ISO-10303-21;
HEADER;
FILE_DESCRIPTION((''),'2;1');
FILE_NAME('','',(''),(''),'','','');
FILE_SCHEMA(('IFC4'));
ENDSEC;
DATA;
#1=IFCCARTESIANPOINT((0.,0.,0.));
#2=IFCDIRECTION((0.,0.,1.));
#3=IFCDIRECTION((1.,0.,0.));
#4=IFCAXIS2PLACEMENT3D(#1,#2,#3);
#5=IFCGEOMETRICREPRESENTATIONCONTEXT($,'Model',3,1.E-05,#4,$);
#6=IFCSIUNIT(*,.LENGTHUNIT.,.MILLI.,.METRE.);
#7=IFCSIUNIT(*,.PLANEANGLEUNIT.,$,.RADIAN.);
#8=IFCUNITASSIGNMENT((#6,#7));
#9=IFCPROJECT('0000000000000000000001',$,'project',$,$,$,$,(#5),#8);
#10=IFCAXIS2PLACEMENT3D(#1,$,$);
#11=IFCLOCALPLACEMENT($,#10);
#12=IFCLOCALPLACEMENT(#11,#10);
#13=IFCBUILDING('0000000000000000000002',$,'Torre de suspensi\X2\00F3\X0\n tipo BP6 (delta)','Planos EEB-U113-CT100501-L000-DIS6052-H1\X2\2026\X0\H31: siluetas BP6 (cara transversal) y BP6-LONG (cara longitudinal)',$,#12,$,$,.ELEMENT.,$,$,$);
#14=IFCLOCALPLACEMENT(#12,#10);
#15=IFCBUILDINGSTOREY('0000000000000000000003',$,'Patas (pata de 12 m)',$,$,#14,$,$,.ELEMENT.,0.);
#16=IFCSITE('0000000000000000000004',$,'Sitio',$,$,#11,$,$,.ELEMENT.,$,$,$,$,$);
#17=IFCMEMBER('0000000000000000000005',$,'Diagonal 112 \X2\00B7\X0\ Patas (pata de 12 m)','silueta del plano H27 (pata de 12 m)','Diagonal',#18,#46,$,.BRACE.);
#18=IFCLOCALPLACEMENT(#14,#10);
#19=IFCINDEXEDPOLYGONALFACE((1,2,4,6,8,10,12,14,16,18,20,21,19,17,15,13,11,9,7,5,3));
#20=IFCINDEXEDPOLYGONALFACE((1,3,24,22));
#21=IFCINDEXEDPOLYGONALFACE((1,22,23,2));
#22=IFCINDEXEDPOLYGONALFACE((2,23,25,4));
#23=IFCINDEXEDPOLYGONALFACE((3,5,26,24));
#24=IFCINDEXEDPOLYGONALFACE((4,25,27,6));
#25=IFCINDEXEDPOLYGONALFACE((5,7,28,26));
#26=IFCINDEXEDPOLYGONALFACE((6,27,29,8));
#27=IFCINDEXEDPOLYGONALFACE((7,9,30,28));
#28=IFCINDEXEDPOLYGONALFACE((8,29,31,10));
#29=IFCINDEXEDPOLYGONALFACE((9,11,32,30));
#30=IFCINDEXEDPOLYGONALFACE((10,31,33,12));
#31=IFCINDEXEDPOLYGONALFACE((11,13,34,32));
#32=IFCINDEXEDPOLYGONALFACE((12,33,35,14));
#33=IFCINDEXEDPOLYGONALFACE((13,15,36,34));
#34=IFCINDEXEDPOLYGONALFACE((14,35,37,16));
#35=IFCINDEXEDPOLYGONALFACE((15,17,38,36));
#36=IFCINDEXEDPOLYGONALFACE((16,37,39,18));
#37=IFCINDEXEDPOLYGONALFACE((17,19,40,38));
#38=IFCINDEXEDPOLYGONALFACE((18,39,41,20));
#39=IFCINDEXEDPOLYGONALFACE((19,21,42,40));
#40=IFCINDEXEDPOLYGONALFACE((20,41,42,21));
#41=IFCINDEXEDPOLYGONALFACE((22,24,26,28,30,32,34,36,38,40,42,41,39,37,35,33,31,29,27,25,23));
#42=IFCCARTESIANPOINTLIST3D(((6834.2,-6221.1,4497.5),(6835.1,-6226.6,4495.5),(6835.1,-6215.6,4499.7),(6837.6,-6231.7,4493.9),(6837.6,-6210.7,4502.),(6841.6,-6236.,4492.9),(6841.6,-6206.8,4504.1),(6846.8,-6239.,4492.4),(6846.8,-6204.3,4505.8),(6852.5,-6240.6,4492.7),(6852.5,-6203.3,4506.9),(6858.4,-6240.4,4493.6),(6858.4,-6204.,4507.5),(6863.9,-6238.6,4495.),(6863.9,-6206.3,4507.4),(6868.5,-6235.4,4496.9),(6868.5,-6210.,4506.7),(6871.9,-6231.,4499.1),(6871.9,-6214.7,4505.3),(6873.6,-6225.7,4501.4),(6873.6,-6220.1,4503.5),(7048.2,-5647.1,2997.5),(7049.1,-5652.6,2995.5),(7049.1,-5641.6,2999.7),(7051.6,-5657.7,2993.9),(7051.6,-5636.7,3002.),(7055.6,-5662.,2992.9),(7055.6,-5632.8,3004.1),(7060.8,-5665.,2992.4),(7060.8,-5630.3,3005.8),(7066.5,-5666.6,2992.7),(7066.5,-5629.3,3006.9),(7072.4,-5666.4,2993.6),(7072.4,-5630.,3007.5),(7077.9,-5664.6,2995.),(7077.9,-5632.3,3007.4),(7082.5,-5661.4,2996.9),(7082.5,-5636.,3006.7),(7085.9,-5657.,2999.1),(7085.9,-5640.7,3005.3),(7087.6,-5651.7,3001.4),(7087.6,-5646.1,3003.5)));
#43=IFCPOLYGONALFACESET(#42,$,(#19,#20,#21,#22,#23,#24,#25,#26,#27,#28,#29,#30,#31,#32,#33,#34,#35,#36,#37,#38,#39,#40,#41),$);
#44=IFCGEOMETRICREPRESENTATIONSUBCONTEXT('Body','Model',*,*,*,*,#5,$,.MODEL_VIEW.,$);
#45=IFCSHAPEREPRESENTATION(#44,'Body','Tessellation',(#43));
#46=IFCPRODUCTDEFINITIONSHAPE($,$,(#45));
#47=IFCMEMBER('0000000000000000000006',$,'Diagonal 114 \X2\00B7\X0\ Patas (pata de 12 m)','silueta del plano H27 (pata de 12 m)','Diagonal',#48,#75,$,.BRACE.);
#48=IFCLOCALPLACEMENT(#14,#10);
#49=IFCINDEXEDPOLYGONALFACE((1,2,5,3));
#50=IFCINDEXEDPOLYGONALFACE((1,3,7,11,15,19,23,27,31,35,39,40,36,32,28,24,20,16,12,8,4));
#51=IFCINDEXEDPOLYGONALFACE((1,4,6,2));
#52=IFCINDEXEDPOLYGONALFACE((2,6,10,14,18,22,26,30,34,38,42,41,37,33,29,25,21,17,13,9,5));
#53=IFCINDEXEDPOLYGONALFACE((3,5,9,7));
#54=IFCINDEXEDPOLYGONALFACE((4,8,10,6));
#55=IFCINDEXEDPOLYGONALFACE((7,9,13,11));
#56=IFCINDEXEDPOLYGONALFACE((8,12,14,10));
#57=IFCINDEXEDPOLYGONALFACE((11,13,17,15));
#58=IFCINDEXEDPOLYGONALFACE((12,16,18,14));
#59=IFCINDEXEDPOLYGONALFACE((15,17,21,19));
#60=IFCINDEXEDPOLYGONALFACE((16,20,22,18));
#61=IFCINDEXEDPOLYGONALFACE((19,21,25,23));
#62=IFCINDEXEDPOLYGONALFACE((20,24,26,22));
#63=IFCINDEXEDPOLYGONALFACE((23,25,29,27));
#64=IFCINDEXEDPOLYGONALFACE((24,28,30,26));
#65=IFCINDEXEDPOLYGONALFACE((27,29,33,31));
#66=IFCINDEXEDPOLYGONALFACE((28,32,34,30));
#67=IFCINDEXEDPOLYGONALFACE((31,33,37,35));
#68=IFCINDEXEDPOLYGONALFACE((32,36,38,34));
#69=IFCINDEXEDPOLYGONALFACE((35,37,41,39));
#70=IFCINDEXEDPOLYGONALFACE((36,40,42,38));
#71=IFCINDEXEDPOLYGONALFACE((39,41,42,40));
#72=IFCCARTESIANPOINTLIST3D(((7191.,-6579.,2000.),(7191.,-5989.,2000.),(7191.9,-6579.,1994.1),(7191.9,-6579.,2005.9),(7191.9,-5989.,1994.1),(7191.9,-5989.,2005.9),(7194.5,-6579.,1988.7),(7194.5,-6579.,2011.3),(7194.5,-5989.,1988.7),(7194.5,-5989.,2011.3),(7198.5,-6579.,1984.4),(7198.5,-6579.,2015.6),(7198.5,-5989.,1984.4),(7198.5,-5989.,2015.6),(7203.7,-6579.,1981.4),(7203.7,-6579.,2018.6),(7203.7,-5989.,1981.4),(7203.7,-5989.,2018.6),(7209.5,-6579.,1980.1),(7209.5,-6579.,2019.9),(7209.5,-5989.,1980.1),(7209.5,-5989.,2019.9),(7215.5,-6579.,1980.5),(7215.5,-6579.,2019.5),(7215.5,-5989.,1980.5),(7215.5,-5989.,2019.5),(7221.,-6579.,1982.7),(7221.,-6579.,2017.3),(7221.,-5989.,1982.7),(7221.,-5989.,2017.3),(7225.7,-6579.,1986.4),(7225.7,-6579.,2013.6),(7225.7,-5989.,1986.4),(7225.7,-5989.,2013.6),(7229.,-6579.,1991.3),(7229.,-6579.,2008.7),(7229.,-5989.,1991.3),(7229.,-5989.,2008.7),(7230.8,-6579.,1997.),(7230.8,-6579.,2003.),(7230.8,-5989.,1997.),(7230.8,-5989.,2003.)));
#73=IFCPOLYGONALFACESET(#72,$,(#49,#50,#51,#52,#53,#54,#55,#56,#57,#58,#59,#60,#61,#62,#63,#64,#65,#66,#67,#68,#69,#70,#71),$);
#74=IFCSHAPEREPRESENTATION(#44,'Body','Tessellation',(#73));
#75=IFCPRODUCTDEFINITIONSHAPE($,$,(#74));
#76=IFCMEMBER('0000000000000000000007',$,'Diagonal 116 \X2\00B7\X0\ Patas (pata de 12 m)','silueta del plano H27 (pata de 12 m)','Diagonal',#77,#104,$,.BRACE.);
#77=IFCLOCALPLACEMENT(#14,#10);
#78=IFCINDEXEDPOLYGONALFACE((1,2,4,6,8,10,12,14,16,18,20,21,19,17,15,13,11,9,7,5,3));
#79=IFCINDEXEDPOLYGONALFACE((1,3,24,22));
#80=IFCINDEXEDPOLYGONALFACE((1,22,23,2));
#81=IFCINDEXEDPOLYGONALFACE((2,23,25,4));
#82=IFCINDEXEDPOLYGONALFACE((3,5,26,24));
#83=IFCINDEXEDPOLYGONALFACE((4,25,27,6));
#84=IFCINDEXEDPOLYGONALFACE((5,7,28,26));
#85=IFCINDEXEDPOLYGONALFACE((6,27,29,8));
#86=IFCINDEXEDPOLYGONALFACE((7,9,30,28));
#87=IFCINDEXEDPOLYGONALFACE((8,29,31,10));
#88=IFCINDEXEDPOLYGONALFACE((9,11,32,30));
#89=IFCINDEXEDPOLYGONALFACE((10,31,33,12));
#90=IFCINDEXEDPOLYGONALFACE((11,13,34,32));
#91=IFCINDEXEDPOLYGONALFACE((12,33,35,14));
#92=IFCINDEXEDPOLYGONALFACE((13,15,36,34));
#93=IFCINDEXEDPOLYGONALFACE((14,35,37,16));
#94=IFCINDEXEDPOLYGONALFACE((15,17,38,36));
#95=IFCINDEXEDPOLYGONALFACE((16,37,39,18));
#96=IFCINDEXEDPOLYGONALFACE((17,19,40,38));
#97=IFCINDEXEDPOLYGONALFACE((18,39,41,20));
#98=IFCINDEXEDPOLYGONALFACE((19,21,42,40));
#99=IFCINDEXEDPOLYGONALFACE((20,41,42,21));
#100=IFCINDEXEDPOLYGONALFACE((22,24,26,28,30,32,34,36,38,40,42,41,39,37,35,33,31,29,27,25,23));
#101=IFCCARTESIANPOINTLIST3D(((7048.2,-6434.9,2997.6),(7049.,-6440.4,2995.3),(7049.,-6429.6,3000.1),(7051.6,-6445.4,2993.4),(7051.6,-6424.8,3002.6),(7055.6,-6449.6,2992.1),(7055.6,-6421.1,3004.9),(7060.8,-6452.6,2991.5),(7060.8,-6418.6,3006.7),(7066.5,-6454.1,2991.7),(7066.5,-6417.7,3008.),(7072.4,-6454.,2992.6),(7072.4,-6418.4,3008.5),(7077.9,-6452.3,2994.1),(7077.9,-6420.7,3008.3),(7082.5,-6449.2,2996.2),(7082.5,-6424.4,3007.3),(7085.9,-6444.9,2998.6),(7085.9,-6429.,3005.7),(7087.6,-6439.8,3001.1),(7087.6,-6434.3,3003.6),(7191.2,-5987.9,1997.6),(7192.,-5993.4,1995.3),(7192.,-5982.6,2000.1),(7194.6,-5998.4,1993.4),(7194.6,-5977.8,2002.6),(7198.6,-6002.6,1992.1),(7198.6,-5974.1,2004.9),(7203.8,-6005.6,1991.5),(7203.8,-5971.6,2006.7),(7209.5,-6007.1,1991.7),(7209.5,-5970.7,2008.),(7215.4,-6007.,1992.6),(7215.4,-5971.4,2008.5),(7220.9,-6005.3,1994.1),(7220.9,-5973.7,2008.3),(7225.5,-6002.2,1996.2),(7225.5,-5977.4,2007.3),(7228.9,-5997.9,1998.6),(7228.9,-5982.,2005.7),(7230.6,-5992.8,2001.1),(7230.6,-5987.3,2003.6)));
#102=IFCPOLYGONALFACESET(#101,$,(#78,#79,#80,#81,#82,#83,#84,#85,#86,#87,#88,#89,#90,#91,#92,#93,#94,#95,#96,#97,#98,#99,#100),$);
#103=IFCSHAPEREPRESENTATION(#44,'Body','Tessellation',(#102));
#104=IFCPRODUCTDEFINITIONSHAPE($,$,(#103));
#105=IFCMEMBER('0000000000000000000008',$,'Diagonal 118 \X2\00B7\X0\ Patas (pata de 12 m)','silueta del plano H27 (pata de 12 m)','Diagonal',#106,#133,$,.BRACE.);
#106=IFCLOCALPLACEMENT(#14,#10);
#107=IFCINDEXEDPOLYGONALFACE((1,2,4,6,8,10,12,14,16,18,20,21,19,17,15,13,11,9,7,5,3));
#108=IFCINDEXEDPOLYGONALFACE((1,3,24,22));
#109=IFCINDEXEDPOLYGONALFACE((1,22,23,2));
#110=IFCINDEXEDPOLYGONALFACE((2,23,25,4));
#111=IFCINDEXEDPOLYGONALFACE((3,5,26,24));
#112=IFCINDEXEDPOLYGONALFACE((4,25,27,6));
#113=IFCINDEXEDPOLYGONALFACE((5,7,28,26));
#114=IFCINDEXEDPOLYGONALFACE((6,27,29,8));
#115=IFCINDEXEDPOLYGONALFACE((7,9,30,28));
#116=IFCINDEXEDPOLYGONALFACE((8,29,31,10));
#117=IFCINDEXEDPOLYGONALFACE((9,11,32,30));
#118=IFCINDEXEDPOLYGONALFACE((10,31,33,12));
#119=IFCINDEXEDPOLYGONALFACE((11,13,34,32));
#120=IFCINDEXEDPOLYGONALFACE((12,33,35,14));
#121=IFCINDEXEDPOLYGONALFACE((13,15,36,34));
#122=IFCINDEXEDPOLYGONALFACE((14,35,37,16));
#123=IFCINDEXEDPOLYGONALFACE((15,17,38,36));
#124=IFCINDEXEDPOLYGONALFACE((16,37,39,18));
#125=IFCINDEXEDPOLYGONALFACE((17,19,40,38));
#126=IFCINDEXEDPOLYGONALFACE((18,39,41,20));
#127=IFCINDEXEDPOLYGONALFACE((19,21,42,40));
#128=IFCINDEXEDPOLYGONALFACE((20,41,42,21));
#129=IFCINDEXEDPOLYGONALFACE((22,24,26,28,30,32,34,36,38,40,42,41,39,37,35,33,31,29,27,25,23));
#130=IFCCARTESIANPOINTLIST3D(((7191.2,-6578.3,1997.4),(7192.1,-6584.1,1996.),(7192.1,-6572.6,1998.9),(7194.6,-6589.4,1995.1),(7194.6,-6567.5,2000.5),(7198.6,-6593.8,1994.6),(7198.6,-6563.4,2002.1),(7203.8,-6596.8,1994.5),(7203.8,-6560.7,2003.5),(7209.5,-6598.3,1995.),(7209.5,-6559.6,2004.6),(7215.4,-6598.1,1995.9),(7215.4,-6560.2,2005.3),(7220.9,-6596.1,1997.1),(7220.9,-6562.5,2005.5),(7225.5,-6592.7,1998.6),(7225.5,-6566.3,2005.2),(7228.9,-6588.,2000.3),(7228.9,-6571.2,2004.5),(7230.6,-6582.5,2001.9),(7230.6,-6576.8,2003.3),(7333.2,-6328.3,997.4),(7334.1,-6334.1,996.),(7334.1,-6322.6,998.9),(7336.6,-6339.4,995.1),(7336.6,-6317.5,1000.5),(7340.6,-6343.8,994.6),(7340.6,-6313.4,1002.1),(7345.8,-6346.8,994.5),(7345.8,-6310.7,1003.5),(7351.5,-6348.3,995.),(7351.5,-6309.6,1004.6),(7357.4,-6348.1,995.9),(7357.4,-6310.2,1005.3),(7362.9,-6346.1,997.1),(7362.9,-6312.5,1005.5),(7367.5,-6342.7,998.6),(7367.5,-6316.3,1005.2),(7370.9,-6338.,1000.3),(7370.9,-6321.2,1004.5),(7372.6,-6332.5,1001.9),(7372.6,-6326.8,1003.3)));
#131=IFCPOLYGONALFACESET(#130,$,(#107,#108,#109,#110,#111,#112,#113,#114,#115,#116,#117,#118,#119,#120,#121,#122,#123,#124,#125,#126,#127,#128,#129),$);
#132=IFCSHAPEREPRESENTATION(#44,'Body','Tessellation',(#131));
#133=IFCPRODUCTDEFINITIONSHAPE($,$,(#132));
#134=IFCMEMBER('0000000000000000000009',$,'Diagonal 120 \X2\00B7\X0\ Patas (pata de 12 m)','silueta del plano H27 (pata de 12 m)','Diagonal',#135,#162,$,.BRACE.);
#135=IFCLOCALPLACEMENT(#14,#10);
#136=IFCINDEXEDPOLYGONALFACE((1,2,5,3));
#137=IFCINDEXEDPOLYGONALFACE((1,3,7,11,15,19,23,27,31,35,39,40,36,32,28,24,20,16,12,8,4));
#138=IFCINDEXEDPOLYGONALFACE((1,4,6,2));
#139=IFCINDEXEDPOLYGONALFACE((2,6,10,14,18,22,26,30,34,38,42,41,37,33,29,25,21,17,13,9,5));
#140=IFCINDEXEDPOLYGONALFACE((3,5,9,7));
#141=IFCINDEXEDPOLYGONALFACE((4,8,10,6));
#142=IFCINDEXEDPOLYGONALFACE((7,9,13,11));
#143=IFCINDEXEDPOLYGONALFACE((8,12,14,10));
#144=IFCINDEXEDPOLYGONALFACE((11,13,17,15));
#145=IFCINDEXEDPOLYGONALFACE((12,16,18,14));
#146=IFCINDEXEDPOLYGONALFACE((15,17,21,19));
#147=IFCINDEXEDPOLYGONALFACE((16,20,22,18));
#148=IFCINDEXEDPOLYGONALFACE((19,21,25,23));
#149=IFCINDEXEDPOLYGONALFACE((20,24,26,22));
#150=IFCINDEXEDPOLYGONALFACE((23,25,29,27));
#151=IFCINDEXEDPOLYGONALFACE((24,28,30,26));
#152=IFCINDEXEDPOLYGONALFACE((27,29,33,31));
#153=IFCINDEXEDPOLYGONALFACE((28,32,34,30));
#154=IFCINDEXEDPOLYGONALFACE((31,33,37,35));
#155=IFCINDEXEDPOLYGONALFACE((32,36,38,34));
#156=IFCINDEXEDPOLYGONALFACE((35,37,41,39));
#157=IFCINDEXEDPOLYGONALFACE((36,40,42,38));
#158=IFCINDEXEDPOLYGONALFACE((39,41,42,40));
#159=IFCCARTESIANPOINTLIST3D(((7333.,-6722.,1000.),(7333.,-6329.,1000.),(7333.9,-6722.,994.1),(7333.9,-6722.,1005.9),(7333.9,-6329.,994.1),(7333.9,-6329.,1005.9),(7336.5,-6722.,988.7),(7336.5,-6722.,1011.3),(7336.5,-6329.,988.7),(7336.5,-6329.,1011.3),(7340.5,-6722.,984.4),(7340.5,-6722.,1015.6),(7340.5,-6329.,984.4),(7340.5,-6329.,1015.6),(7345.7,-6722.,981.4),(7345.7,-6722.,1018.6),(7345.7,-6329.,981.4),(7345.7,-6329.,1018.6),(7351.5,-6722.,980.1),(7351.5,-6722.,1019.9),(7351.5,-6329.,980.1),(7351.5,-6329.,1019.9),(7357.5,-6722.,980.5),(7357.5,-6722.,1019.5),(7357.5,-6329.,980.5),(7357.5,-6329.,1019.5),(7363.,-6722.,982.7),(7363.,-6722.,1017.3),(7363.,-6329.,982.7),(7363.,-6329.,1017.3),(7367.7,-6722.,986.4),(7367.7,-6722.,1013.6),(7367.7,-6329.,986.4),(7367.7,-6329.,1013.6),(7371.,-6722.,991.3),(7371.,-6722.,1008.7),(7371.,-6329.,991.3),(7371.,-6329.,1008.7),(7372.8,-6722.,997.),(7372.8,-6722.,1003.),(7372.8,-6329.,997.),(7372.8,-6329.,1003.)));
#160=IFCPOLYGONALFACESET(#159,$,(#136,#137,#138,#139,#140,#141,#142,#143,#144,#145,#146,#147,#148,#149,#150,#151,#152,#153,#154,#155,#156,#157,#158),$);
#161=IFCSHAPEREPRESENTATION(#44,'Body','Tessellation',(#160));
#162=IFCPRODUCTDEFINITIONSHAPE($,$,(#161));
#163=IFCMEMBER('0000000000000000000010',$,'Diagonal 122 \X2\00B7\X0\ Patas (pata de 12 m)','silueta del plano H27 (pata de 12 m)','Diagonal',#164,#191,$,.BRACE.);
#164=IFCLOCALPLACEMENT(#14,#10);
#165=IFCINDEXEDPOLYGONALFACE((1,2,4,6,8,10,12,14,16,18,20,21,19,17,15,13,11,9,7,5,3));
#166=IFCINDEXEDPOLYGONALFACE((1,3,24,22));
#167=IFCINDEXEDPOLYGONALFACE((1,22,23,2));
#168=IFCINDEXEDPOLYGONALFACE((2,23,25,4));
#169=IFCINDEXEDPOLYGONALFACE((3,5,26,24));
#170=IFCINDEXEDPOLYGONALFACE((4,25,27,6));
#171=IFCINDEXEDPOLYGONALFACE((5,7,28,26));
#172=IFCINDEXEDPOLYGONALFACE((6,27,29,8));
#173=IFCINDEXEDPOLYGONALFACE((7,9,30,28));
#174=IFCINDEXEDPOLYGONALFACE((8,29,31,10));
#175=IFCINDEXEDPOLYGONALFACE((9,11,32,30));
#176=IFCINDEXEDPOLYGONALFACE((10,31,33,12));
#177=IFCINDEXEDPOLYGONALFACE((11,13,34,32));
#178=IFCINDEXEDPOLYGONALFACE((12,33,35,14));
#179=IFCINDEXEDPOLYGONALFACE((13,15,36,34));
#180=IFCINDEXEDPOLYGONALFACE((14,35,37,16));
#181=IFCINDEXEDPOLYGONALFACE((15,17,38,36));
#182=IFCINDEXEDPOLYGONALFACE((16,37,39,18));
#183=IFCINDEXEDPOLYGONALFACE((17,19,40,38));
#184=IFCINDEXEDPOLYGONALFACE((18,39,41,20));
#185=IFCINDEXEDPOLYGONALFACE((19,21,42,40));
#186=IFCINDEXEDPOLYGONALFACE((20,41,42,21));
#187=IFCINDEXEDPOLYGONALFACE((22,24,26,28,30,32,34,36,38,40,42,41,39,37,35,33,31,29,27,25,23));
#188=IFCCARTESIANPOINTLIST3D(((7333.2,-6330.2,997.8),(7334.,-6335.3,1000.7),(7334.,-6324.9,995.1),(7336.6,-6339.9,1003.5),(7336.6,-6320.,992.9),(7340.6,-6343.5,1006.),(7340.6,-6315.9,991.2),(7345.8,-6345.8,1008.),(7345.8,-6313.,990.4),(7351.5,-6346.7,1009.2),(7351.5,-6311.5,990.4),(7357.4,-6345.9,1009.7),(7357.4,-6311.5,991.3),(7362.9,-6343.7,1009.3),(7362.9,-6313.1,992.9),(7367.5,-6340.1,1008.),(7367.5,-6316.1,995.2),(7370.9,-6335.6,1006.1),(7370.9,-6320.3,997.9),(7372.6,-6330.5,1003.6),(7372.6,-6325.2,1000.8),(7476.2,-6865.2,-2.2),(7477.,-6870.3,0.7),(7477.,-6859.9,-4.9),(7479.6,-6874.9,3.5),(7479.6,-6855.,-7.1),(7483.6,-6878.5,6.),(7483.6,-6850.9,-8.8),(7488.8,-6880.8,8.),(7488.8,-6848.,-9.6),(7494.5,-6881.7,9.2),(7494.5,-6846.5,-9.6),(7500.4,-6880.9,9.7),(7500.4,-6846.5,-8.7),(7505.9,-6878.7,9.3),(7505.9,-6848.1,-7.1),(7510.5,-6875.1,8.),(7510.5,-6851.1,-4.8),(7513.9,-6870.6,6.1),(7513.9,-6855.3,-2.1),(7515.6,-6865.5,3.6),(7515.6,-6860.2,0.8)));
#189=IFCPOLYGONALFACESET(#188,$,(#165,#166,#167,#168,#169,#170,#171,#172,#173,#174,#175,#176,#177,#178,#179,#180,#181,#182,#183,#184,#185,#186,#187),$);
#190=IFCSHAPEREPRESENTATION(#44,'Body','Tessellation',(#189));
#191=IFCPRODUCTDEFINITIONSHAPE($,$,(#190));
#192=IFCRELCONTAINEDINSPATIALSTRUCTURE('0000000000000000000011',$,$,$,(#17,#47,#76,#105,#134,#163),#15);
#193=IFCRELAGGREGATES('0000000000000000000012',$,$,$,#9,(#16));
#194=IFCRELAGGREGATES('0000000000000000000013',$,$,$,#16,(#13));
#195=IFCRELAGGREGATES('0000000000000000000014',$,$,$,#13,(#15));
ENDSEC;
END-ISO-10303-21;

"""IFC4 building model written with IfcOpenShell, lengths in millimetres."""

from ifc_helpers import new_model, si_unit, frame, origin, origin_with_axes, place, context, subcontext, project, spatial, circle, extrude, element, save


model = new_model("IFC4")

# Units and contexts
model_context = context("Model", 3, precision=1e-05, world=origin_with_axes())
body_context = subcontext(model_context, "Body", "Model", "MODEL_VIEW")
ifc_project = project(units=[si_unit("LENGTHUNIT", "METRE", prefix="MILLI"), si_unit("PLANEANGLEUNIT", "RADIAN")], contexts=[model_context])

# Site, building, storey
site_placement = place(None, origin())
site = spatial("IfcSite", under=ifc_project, at=site_placement, Name="Sitio", CompositionType="ELEMENT")
building_placement = place(site_placement, origin())
building = spatial("IfcBuilding", under=site, at=building_placement, Name="Torre de suspensión tipo BP6 (delta)", Description="Planos EEB-U113-CT100501-L000-DIS6052-H1…H31: siluetas BP6 (cara transversal) y BP6-LONG (cara longitudinal)", CompositionType="ELEMENT")
storey_placement = place(building_placement, origin())
storey = spatial("IfcBuildingStorey", under=building, at=storey_placement, Name="Patas (pata de 12 m)", CompositionType="ELEMENT", Elevation=0.0)

# Members
member_1_placement = place(storey_placement, frame((7068.0, -5648.0, 3000.0), z_axis=(-0.132077, -0.354262, 0.925772), x_axis=(-0.991239, 0.047203, -0.123354)))
element("IfcMember", 1, at=member_1_placement, inside=storey, Name="Diagonal 112 · Patas (pata de 12 m)", Description="silueta del plano H27 (pata de 12 m)", ObjectType="Diagonal", PredefinedType="BRACE", context=body_context, shape_type="SweptSolid", body=[
    extrude(circle(Radius=20.0), None, (0.0, 0.0, 1.0), 1620.3),
])
member_2_placement = place(storey_placement, frame((7211.0, -6579.0, 2000.0), z_axis=(0.0, 1.0, 0.0), x_axis=(-1.0, 0.0, 0.0)))
element("IfcMember", 2, at=member_2_placement, inside=storey, Name="Diagonal 114 · Patas (pata de 12 m)", Description="silueta del plano H27 (pata de 12 m)", ObjectType="Diagonal", PredefinedType="BRACE", context=body_context, shape_type="SweptSolid", body=[
    extrude(circle(Radius=20.0), None, (0.0, 0.0, 1.0), 590.0),
])
member_3_placement = place(storey_placement, frame((7211.0, -5989.0, 2000.0), z_axis=(-0.129452, -0.404652, 0.905262), x_axis=(-0.991586, 0.052828, -0.118183)))
element("IfcMember", 3, at=member_3_placement, inside=storey, Name="Diagonal 116 · Patas (pata de 12 m)", Description="silueta del plano H27 (pata de 12 m)", ObjectType="Diagonal", PredefinedType="BRACE", context=body_context, shape_type="SweptSolid", body=[
    extrude(circle(Radius=20.0), None, (0.0, 0.0, 1.0), 1104.7),
])
member_4_placement = place(storey_placement, frame((7353.0, -6329.0, 1000.0), z_axis=(-0.136471, -0.240266, 0.961066), x_axis=(-0.990644, 0.033099, -0.132397)))
element("IfcMember", 4, at=member_4_placement, inside=storey, Name="Diagonal 118 · Patas (pata de 12 m)", Description="silueta del plano H27 (pata de 12 m)", ObjectType="Diagonal", PredefinedType="BRACE", context=body_context, shape_type="SweptSolid", body=[
    extrude(circle(Radius=20.0), None, (0.0, 0.0, 1.0), 1040.5),
])
member_5_placement = place(storey_placement, frame((7353.0, -6722.0, 1000.0), z_axis=(0.0, 1.0, 0.0), x_axis=(-1.0, 0.0, 0.0)))
element("IfcMember", 5, at=member_5_placement, inside=storey, Name="Diagonal 120 · Patas (pata de 12 m)", Description="silueta del plano H27 (pata de 12 m)", ObjectType="Diagonal", PredefinedType="BRACE", context=body_context, shape_type="SweptSolid", body=[
    extrude(circle(Radius=20.0), None, (0.0, 0.0, 1.0), 393.0),
])
member_6_placement = place(storey_placement, frame((7496.0, -6864.0, 0.0), z_axis=(-0.125099, 0.468026, 0.874815), x_axis=(-0.992144, -0.059013, -0.110305)))
element("IfcMember", 6, at=member_6_placement, inside=storey, Name="Diagonal 122 · Patas (pata de 12 m)", Description="silueta del plano H27 (pata de 12 m)", ObjectType="Diagonal", PredefinedType="BRACE", context=body_context, shape_type="SweptSolid", body=[
    extrude(circle(Radius=20.0), None, (0.0, 0.0, 1.0), 1143.1),
])

save(model, "model.ifc")
